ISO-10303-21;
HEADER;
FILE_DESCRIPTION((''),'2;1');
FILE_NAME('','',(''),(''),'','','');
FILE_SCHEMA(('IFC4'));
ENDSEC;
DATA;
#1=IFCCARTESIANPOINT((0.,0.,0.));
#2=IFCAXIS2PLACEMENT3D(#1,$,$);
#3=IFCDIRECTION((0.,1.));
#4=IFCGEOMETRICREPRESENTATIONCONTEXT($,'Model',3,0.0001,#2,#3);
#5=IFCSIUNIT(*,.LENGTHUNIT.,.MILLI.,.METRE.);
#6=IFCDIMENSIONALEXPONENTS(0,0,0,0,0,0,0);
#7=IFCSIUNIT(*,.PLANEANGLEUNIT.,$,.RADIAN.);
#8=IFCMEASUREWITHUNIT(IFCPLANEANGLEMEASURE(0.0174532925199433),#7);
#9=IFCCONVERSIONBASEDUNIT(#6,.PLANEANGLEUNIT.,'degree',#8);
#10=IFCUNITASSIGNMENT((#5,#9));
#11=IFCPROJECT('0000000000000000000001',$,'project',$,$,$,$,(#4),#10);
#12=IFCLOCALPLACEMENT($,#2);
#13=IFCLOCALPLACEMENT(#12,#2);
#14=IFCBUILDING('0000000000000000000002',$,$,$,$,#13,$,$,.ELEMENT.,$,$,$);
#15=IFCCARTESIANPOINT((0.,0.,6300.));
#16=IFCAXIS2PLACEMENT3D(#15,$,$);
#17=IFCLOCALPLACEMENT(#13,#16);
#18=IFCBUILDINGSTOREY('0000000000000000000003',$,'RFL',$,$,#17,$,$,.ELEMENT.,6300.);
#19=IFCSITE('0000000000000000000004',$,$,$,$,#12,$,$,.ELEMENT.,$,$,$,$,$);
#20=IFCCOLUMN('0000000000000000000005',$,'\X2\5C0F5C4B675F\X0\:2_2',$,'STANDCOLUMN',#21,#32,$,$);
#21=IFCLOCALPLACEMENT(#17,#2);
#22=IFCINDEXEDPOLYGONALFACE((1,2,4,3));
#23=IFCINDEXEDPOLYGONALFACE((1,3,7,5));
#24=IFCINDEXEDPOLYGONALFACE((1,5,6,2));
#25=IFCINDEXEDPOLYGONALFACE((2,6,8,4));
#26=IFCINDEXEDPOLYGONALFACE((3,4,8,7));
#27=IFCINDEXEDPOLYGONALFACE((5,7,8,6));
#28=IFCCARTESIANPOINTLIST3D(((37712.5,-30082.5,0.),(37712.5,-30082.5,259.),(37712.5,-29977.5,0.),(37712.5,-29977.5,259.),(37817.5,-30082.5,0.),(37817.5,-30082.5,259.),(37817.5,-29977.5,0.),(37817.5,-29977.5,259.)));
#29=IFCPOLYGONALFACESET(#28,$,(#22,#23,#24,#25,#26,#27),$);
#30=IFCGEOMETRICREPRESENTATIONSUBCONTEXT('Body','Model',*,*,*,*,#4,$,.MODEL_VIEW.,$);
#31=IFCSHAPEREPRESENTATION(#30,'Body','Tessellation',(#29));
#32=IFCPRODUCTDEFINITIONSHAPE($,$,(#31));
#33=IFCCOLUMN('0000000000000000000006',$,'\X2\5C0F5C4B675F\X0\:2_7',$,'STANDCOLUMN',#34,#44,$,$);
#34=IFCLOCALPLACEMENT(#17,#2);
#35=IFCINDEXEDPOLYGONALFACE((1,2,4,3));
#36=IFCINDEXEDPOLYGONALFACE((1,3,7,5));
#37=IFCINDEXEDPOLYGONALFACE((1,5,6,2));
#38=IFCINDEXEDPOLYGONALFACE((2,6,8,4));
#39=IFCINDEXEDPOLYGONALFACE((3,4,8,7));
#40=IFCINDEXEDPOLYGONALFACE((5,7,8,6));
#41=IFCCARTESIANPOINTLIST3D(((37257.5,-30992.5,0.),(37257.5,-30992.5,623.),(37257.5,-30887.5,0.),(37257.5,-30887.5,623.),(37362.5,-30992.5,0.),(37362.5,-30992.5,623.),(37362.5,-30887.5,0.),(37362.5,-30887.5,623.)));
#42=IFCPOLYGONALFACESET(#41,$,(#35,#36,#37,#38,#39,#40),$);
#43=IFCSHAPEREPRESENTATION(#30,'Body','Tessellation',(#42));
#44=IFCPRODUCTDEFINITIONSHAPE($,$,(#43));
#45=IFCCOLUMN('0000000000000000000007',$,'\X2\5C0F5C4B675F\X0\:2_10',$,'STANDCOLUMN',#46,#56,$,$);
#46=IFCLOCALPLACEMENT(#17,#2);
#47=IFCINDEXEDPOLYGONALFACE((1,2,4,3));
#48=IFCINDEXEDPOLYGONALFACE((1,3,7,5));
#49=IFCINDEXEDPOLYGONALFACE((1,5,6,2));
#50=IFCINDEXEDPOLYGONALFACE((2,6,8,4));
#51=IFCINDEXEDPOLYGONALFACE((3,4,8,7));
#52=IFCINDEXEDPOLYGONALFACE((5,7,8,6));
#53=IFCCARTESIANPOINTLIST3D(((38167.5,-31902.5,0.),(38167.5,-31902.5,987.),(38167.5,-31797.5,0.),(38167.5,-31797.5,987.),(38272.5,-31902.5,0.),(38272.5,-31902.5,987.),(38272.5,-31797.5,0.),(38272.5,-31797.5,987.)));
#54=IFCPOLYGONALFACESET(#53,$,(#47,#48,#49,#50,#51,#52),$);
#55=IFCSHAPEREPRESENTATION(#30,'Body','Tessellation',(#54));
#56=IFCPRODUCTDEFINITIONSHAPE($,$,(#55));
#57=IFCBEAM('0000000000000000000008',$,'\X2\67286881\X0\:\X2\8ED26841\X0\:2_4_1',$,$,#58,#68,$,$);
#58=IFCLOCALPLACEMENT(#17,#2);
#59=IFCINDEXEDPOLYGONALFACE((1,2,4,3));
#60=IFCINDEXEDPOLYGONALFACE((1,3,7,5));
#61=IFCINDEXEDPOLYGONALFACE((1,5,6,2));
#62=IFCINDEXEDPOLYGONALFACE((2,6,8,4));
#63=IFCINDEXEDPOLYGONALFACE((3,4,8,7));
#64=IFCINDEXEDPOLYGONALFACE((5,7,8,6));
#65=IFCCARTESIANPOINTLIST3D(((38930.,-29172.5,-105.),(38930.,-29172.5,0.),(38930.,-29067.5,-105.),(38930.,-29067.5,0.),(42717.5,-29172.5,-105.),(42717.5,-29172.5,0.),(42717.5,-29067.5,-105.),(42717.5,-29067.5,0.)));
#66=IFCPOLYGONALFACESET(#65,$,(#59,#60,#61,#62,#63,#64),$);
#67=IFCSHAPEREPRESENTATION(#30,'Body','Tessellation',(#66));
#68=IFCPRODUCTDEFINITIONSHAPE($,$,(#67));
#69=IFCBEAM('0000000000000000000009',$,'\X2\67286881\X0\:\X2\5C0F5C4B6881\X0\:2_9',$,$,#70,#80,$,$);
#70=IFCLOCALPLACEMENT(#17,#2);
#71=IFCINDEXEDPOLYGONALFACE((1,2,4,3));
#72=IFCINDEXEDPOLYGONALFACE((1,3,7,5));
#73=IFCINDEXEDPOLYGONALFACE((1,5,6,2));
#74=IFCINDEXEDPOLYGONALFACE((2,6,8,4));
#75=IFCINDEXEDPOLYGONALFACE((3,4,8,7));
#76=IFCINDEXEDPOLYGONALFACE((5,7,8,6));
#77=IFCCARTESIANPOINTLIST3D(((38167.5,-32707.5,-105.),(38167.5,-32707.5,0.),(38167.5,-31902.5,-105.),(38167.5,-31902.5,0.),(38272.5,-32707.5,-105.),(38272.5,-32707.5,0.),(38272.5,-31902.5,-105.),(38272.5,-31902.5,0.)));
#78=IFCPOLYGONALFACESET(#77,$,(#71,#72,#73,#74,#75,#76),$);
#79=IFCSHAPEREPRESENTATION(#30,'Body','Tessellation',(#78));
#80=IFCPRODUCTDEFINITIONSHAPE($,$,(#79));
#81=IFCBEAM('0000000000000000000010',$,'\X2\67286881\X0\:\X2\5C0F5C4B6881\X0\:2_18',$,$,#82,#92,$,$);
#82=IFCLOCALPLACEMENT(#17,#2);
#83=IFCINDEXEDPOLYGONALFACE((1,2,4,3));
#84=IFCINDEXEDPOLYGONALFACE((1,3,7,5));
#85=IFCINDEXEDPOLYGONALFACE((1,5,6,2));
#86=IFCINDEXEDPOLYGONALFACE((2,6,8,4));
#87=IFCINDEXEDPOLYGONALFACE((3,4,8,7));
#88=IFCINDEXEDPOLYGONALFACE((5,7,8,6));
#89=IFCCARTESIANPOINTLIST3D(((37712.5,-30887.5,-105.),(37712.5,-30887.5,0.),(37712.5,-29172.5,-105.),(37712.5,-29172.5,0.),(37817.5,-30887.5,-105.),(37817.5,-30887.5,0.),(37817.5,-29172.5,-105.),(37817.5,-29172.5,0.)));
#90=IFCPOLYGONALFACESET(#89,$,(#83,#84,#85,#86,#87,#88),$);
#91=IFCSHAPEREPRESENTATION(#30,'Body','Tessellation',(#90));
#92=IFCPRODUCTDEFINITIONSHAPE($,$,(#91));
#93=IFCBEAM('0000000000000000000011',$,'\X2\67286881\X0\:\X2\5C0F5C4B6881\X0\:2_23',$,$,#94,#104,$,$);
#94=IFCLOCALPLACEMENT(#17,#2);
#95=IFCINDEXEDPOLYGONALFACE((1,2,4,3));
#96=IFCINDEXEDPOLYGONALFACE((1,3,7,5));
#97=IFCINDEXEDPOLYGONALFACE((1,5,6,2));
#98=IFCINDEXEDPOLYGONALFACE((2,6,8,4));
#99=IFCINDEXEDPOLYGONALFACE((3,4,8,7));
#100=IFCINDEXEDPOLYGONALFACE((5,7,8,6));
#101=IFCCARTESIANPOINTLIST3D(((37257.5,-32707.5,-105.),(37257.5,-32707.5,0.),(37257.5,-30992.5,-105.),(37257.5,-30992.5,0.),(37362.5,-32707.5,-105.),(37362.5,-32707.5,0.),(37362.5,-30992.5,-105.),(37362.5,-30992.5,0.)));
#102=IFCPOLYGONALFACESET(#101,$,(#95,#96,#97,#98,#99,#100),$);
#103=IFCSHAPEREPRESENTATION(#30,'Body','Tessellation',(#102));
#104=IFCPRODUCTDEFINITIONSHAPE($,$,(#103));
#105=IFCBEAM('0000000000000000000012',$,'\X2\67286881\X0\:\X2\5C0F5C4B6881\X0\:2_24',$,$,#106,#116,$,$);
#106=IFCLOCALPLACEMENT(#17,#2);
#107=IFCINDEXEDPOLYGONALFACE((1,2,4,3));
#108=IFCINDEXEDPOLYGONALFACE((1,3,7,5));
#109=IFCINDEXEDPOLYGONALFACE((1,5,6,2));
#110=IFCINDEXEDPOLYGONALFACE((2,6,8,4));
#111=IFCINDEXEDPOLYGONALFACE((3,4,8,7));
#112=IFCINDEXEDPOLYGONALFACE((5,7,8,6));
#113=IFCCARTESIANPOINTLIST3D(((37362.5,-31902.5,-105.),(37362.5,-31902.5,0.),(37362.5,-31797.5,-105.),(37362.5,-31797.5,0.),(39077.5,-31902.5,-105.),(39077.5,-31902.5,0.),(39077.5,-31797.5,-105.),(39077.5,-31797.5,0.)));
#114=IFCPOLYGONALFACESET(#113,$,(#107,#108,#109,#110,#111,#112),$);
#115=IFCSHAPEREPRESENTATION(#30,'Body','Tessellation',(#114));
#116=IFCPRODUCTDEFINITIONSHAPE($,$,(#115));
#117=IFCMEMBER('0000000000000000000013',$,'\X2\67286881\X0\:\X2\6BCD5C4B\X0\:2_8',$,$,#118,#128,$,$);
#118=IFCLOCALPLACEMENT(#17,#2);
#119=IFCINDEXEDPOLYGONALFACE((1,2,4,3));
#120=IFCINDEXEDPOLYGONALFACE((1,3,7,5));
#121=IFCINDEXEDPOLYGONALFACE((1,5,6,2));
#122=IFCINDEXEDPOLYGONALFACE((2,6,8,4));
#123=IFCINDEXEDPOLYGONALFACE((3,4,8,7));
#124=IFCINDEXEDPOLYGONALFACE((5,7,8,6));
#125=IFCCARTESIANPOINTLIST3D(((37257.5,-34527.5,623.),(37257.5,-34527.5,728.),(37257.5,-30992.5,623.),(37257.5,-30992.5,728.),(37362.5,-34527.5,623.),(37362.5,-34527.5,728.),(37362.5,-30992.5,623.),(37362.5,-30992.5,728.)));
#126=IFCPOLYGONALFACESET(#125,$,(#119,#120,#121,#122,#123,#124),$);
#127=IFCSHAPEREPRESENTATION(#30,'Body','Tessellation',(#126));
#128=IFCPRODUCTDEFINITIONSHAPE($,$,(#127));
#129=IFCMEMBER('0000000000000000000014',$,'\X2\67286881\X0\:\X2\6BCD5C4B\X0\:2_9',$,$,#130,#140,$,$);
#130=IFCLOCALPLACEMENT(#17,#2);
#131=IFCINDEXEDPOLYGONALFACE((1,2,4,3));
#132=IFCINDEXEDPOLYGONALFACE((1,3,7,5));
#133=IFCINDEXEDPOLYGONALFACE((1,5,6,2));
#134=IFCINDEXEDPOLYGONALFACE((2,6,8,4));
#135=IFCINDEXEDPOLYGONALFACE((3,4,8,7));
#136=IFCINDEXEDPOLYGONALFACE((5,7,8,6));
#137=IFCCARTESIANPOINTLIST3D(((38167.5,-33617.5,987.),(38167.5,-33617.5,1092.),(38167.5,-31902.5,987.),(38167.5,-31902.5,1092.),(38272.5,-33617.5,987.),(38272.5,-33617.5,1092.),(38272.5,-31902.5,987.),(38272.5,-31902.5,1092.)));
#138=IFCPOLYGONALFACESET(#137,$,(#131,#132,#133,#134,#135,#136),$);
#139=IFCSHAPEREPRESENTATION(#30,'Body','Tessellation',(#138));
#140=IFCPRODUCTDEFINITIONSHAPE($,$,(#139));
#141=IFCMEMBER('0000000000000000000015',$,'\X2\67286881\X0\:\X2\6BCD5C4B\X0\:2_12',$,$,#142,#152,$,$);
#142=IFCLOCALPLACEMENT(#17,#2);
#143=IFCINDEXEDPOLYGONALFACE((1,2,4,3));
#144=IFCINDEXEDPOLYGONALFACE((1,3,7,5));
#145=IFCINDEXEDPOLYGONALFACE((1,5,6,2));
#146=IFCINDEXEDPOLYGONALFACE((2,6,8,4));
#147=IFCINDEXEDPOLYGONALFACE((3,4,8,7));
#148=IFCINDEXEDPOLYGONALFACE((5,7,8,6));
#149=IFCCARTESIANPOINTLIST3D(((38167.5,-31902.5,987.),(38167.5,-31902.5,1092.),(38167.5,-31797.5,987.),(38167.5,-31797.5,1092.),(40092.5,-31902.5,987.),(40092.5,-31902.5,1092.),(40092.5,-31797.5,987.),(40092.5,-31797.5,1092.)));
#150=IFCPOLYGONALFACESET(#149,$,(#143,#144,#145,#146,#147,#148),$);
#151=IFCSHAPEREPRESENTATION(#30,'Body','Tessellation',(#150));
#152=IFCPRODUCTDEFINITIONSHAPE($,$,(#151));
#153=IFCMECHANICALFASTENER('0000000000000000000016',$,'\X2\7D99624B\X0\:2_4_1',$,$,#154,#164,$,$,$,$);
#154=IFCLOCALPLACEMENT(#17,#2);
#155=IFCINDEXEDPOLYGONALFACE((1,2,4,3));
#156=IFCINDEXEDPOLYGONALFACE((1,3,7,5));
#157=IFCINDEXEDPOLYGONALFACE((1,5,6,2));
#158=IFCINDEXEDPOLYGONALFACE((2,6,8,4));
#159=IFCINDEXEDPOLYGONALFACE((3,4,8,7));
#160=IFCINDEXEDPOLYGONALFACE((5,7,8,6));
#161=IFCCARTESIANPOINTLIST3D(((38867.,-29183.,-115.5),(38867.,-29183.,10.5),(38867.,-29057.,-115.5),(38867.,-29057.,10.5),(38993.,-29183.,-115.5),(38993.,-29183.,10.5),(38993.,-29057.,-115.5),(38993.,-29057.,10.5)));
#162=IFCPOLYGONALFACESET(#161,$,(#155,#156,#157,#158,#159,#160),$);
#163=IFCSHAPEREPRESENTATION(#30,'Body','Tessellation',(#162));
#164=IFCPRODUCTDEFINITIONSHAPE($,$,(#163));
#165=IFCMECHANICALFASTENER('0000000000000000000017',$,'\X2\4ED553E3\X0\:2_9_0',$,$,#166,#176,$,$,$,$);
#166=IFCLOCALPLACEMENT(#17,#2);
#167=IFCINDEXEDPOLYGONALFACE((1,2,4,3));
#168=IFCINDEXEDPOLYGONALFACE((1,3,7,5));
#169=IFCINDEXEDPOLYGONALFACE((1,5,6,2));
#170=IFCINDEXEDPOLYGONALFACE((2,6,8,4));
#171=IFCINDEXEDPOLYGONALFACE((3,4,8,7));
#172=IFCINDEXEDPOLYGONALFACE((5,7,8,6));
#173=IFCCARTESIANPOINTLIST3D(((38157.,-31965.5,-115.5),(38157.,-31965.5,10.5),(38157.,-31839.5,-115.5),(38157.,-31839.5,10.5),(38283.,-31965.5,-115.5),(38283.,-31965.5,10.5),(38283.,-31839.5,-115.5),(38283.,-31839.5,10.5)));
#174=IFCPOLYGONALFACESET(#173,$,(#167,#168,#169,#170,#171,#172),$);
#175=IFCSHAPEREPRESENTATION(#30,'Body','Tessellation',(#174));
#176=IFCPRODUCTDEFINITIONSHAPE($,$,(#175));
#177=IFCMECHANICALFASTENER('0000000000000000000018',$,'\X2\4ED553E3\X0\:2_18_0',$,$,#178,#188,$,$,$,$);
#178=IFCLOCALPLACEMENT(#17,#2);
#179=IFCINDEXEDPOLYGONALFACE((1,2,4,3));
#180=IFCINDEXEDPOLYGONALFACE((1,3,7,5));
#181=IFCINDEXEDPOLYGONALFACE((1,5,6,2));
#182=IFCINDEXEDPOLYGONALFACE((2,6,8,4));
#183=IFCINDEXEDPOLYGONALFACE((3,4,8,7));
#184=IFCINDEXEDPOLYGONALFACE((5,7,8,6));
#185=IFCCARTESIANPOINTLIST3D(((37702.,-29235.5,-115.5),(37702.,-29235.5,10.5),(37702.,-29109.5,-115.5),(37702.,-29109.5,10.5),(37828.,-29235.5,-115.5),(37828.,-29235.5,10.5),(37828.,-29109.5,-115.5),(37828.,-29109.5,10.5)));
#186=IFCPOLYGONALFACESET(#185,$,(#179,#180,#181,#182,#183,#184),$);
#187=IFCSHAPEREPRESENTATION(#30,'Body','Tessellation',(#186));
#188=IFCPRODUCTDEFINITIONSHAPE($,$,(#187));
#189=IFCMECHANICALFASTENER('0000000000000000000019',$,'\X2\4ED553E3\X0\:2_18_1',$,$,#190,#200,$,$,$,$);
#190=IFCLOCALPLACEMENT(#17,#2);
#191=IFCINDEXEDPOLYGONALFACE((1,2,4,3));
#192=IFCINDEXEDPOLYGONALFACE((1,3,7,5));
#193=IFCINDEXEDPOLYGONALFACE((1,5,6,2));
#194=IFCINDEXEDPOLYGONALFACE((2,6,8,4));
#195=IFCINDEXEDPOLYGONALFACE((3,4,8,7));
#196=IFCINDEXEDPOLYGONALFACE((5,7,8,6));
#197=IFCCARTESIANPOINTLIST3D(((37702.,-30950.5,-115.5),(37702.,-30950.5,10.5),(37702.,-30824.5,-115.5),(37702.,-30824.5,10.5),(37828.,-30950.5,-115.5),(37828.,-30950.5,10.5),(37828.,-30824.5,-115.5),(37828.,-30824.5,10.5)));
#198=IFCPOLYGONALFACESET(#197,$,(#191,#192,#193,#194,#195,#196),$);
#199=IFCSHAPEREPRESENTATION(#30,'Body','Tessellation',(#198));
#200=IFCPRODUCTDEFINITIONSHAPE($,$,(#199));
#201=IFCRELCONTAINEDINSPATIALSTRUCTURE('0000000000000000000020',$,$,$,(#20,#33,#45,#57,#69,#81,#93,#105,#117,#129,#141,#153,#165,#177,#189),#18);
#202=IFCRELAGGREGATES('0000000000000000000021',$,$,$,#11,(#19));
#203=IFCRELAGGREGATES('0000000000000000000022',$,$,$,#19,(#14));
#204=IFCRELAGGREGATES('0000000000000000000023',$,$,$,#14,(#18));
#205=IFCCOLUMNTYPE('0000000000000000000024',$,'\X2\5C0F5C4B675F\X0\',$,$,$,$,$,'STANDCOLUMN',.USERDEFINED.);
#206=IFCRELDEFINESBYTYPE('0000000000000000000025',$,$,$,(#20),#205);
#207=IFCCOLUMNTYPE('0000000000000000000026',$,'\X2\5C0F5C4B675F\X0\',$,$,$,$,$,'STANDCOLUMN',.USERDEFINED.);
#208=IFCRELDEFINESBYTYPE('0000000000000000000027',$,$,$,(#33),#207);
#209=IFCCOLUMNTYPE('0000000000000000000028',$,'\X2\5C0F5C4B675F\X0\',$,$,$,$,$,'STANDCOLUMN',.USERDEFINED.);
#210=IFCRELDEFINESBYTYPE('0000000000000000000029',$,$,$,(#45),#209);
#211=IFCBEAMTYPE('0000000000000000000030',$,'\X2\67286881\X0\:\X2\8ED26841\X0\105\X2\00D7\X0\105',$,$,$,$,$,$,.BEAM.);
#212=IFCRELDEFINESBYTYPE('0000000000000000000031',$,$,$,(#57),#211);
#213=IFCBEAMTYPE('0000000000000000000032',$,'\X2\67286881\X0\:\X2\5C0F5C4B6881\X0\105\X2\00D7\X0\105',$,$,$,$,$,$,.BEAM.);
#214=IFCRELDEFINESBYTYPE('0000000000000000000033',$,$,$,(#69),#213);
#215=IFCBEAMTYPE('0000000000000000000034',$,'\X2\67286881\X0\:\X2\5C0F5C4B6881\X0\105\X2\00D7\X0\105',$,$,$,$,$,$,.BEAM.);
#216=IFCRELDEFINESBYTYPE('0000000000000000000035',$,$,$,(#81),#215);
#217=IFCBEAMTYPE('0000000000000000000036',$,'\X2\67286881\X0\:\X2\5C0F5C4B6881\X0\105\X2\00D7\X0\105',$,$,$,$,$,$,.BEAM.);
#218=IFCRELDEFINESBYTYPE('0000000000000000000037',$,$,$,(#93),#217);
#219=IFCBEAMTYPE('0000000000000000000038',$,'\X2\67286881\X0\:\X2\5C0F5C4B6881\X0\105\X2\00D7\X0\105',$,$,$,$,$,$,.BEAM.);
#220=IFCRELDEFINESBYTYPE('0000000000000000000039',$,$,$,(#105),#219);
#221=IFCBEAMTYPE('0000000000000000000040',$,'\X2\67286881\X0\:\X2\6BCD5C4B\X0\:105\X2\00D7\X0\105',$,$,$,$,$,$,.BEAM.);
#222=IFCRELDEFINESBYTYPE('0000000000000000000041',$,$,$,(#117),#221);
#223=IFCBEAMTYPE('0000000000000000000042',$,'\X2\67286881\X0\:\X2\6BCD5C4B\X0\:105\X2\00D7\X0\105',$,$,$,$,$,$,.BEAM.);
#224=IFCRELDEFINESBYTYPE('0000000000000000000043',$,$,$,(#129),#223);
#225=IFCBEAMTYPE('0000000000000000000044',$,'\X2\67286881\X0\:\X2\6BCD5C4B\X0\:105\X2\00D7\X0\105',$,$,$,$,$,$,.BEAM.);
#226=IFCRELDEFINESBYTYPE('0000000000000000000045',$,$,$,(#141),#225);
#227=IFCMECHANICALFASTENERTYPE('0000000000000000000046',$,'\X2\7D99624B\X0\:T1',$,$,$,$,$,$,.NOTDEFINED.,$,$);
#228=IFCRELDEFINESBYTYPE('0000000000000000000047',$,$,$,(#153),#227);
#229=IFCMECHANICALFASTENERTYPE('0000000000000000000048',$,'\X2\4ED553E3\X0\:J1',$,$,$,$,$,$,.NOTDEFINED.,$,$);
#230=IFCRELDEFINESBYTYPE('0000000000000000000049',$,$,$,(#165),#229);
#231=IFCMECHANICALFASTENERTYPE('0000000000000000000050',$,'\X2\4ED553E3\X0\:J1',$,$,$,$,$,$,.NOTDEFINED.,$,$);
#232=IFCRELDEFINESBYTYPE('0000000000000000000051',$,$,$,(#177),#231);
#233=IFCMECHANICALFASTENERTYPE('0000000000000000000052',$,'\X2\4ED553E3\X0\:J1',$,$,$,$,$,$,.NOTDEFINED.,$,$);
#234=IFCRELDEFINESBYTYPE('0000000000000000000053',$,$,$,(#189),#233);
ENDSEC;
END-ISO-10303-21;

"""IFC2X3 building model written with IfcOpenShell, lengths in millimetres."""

from ifc_helpers import new_model, entity, si_unit, converted_unit, direction, frame, origin, origin_with_axes, origin_2d, place, context, subcontext, project, spatial, rectangle, extrude, type_object, element, save


model = new_model("IFC2X3")

# Units and contexts
model_context = context("Model", 3, precision=0.0001, world=origin(), true_north=direction((0.0, 1.0)))
body_context = subcontext(model_context, "Body", "Model", "MODEL_VIEW")
ifc_project = project(units=[si_unit("LENGTHUNIT", "METRE", prefix="MILLI"), converted_unit("PLANEANGLEUNIT", "degree", entity("IfcPlaneAngleMeasure", 0.0174532925199433), si_unit("PLANEANGLEUNIT", "RADIAN"), dimensions=[0, 0, 0, 0, 0, 0, 0])], contexts=[model_context])

# Site, building, storey
site_placement = place(None, origin())
site = spatial("IfcSite", under=ifc_project, at=site_placement, CompositionType="ELEMENT")
building_placement = place(site_placement, origin())
building = spatial("IfcBuilding", under=site, at=building_placement, CompositionType="ELEMENT")
storey_placement = place(building_placement, frame((0.0, 0.0, 6300.0)))
storey = spatial("IfcBuildingStorey", under=building, at=storey_placement, Name="RFL", CompositionType="ELEMENT", Elevation=6300.0)

# Columns
column_type_1 = type_object("IfcColumnType", Name="小屋束", ElementType="STANDCOLUMN", PredefinedType="USERDEFINED")
column_1_placement = place(storey_placement, frame((37765.0, -30030.0, 0.0)))
element("IfcColumn", 1, at=column_1_placement, inside=storey, type_object=column_type_1, Name="小屋束:2_2", ObjectType="STANDCOLUMN", context=body_context, shape_type="SweptSolid", body=[
    extrude(rectangle(XDim=105.0, YDim=105.0, at=origin_2d()), origin_with_axes(), (0.0, 0.0, 1.0), 259.0),
])
column_type_2 = type_object("IfcColumnType", Name="小屋束", ElementType="STANDCOLUMN", PredefinedType="USERDEFINED")
column_2_placement = place(storey_placement, frame((37310.0, -30940.0, 0.0)))
element("IfcColumn", 2, at=column_2_placement, inside=storey, type_object=column_type_2, Name="小屋束:2_7", ObjectType="STANDCOLUMN", context=body_context, shape_type="SweptSolid", body=[
    extrude(rectangle(XDim=105.0, YDim=105.0, at=origin_2d()), origin_with_axes(), (0.0, 0.0, 1.0), 623.0),
])
column_type_3 = type_object("IfcColumnType", Name="小屋束", ElementType="STANDCOLUMN", PredefinedType="USERDEFINED")
column_3_placement = place(storey_placement, frame((38220.0, -31850.0, 0.0)))
element("IfcColumn", 3, at=column_3_placement, inside=storey, type_object=column_type_3, Name="小屋束:2_10", ObjectType="STANDCOLUMN", context=body_context, shape_type="SweptSolid", body=[
    extrude(rectangle(XDim=105.0, YDim=105.0, at=origin_2d()), origin_with_axes(), (0.0, 0.0, 1.0), 987.0),
])

# Beams
beam_type_1 = type_object("IfcBeamType", Name="木梁:軒桁105×105", PredefinedType="BEAM")
beam_1_placement = place(storey_placement, frame((38930.0, -29120.0, -52.5), z_axis=(1.0, 0.0, 0.0), x_axis=(0.0, 1.0, 0.0)))
element("IfcBeam", 4, at=beam_1_placement, inside=storey, type_object=beam_type_1, Name="木梁:軒桁:2_4_1", context=body_context, shape_type="SweptSolid", body=[
    extrude(rectangle(XDim=105.0, YDim=105.0, at=origin_2d()), origin_with_axes(), (0.0, 0.0, 1.0), 3787.5),
])
beam_type_2 = type_object("IfcBeamType", Name="木梁:小屋梁105×105", PredefinedType="BEAM")
beam_2_placement = place(storey_placement, frame((38220.0, -31902.5, -52.5), z_axis=(0.0, -1.0, 0.0), x_axis=(1.0, 0.0, 0.0)))
element("IfcBeam", 5, at=beam_2_placement, inside=storey, type_object=beam_type_2, Name="木梁:小屋梁:2_9", context=body_context, shape_type="SweptSolid", body=[
    extrude(rectangle(XDim=105.0, YDim=105.0, at=origin_2d()), origin_with_axes(), (0.0, 0.0, 1.0), 805.0),
])
beam_type_3 = type_object("IfcBeamType", Name="木梁:小屋梁105×105", PredefinedType="BEAM")
beam_3_placement = place(storey_placement, frame((37765.0, -29172.5, -52.5), z_axis=(0.0, -1.0, 0.0), x_axis=(1.0, 0.0, 0.0)))
element("IfcBeam", 6, at=beam_3_placement, inside=storey, type_object=beam_type_3, Name="木梁:小屋梁:2_18", context=body_context, shape_type="SweptSolid", body=[
    extrude(rectangle(XDim=105.0, YDim=105.0, at=origin_2d()), origin_with_axes(), (0.0, 0.0, 1.0), 1715.0),
])
beam_type_4 = type_object("IfcBeamType", Name="木梁:小屋梁105×105", PredefinedType="BEAM")
beam_4_placement = place(storey_placement, frame((37310.0, -30992.5, -52.5), z_axis=(0.0, -1.0, 0.0), x_axis=(1.0, 0.0, 0.0)))
element("IfcBeam", 7, at=beam_4_placement, inside=storey, type_object=beam_type_4, Name="木梁:小屋梁:2_23", context=body_context, shape_type="SweptSolid", body=[
    extrude(rectangle(XDim=105.0, YDim=105.0, at=origin_2d()), origin_with_axes(), (0.0, 0.0, 1.0), 1715.0),
])
beam_type_5 = type_object("IfcBeamType", Name="木梁:小屋梁105×105", PredefinedType="BEAM")
beam_5_placement = place(storey_placement, frame((37362.5, -31850.0, -52.5), z_axis=(1.0, 0.0, 0.0), x_axis=(0.0, 1.0, 0.0)))
element("IfcBeam", 8, at=beam_5_placement, inside=storey, type_object=beam_type_5, Name="木梁:小屋梁:2_24", context=body_context, shape_type="SweptSolid", body=[
    extrude(rectangle(XDim=105.0, YDim=105.0, at=origin_2d()), origin_with_axes(), (0.0, 0.0, 1.0), 1715.0),
])

# Members
beam_type_6 = type_object("IfcBeamType", Name="木梁:母屋:105×105", PredefinedType="BEAM")
member_1_placement = place(storey_placement, frame((37310.0, -30992.5, 675.5), z_axis=(0.0, -1.0, 0.0), x_axis=(-1.0, 0.0, 0.0)))
element("IfcMember", 9, at=member_1_placement, inside=storey, type_object=beam_type_6, Name="木梁:母屋:2_8", context=body_context, shape_type="SweptSolid", body=[
    extrude(rectangle(XDim=105.0, YDim=105.0, at=origin_2d()), origin_with_axes(), (0.0, 0.0, 1.0), 3535.0),
])
beam_type_7 = type_object("IfcBeamType", Name="木梁:母屋:105×105", PredefinedType="BEAM")
member_2_placement = place(storey_placement, frame((38220.0, -31902.5, 1039.5), z_axis=(0.0, -1.0, 0.0), x_axis=(-1.0, 0.0, 0.0)))
element("IfcMember", 10, at=member_2_placement, inside=storey, type_object=beam_type_7, Name="木梁:母屋:2_9", context=body_context, shape_type="SweptSolid", body=[
    extrude(rectangle(XDim=105.0, YDim=105.0, at=origin_2d()), origin_with_axes(), (0.0, 0.0, 1.0), 1715.0),
])
beam_type_8 = type_object("IfcBeamType", Name="木梁:母屋:105×105", PredefinedType="BEAM")
member_3_placement = place(storey_placement, frame((38167.5, -31850.0, 1039.5), z_axis=(1.0, 0.0, 0.0), x_axis=(0.0, -1.0, 0.0)))
element("IfcMember", 11, at=member_3_placement, inside=storey, type_object=beam_type_8, Name="木梁:母屋:2_12", context=body_context, shape_type="SweptSolid", body=[
    extrude(rectangle(XDim=105.0, YDim=105.0, at=origin_2d()), origin_with_axes(), (0.0, 0.0, 1.0), 1925.0),
])

# Mechanical fasteners
mechanical_fastener_type_1 = type_object("IfcMechanicalFastenerType", Name="継手:T1")
mechanical_fastener_1_placement = place(storey_placement, frame((38930.0, -29120.0, -115.5)))
element("IfcMechanicalFastener", 12, at=mechanical_fastener_1_placement, inside=storey, type_object=mechanical_fastener_type_1, Name="継手:2_4_1", context=body_context, shape_type="SweptSolid", body=[
    extrude(rectangle(XDim=126.0, YDim=126.0, at=origin_2d()), origin_with_axes(), (0.0, 0.0, 1.0), 126.0),
])
mechanical_fastener_type_2 = type_object("IfcMechanicalFastenerType", Name="仕口:J1")
mechanical_fastener_2_placement = place(storey_placement, frame((38220.0, -31902.5, -115.5)))
element("IfcMechanicalFastener", 13, at=mechanical_fastener_2_placement, inside=storey, type_object=mechanical_fastener_type_2, Name="仕口:2_9_0", context=body_context, shape_type="SweptSolid", body=[
    extrude(rectangle(XDim=126.0, YDim=126.0, at=origin_2d()), origin_with_axes(), (0.0, 0.0, 1.0), 126.0),
])
mechanical_fastener_type_3 = type_object("IfcMechanicalFastenerType", Name="仕口:J1")
mechanical_fastener_3_placement = place(storey_placement, frame((37765.0, -29172.5, -115.5)))
element("IfcMechanicalFastener", 14, at=mechanical_fastener_3_placement, inside=storey, type_object=mechanical_fastener_type_3, Name="仕口:2_18_0", context=body_context, shape_type="SweptSolid", body=[
    extrude(rectangle(XDim=126.0, YDim=126.0, at=origin_2d()), origin_with_axes(), (0.0, 0.0, 1.0), 126.0),
])
mechanical_fastener_type_4 = type_object("IfcMechanicalFastenerType", Name="仕口:J1")
mechanical_fastener_4_placement = place(storey_placement, frame((37765.0, -30887.5, -115.5)))
element("IfcMechanicalFastener", 15, at=mechanical_fastener_4_placement, inside=storey, type_object=mechanical_fastener_type_4, Name="仕口:2_18_1", context=body_context, shape_type="SweptSolid", body=[
    extrude(rectangle(XDim=126.0, YDim=126.0, at=origin_2d()), origin_with_axes(), (0.0, 0.0, 1.0), 126.0),
])

save(model, "model.ifc")
